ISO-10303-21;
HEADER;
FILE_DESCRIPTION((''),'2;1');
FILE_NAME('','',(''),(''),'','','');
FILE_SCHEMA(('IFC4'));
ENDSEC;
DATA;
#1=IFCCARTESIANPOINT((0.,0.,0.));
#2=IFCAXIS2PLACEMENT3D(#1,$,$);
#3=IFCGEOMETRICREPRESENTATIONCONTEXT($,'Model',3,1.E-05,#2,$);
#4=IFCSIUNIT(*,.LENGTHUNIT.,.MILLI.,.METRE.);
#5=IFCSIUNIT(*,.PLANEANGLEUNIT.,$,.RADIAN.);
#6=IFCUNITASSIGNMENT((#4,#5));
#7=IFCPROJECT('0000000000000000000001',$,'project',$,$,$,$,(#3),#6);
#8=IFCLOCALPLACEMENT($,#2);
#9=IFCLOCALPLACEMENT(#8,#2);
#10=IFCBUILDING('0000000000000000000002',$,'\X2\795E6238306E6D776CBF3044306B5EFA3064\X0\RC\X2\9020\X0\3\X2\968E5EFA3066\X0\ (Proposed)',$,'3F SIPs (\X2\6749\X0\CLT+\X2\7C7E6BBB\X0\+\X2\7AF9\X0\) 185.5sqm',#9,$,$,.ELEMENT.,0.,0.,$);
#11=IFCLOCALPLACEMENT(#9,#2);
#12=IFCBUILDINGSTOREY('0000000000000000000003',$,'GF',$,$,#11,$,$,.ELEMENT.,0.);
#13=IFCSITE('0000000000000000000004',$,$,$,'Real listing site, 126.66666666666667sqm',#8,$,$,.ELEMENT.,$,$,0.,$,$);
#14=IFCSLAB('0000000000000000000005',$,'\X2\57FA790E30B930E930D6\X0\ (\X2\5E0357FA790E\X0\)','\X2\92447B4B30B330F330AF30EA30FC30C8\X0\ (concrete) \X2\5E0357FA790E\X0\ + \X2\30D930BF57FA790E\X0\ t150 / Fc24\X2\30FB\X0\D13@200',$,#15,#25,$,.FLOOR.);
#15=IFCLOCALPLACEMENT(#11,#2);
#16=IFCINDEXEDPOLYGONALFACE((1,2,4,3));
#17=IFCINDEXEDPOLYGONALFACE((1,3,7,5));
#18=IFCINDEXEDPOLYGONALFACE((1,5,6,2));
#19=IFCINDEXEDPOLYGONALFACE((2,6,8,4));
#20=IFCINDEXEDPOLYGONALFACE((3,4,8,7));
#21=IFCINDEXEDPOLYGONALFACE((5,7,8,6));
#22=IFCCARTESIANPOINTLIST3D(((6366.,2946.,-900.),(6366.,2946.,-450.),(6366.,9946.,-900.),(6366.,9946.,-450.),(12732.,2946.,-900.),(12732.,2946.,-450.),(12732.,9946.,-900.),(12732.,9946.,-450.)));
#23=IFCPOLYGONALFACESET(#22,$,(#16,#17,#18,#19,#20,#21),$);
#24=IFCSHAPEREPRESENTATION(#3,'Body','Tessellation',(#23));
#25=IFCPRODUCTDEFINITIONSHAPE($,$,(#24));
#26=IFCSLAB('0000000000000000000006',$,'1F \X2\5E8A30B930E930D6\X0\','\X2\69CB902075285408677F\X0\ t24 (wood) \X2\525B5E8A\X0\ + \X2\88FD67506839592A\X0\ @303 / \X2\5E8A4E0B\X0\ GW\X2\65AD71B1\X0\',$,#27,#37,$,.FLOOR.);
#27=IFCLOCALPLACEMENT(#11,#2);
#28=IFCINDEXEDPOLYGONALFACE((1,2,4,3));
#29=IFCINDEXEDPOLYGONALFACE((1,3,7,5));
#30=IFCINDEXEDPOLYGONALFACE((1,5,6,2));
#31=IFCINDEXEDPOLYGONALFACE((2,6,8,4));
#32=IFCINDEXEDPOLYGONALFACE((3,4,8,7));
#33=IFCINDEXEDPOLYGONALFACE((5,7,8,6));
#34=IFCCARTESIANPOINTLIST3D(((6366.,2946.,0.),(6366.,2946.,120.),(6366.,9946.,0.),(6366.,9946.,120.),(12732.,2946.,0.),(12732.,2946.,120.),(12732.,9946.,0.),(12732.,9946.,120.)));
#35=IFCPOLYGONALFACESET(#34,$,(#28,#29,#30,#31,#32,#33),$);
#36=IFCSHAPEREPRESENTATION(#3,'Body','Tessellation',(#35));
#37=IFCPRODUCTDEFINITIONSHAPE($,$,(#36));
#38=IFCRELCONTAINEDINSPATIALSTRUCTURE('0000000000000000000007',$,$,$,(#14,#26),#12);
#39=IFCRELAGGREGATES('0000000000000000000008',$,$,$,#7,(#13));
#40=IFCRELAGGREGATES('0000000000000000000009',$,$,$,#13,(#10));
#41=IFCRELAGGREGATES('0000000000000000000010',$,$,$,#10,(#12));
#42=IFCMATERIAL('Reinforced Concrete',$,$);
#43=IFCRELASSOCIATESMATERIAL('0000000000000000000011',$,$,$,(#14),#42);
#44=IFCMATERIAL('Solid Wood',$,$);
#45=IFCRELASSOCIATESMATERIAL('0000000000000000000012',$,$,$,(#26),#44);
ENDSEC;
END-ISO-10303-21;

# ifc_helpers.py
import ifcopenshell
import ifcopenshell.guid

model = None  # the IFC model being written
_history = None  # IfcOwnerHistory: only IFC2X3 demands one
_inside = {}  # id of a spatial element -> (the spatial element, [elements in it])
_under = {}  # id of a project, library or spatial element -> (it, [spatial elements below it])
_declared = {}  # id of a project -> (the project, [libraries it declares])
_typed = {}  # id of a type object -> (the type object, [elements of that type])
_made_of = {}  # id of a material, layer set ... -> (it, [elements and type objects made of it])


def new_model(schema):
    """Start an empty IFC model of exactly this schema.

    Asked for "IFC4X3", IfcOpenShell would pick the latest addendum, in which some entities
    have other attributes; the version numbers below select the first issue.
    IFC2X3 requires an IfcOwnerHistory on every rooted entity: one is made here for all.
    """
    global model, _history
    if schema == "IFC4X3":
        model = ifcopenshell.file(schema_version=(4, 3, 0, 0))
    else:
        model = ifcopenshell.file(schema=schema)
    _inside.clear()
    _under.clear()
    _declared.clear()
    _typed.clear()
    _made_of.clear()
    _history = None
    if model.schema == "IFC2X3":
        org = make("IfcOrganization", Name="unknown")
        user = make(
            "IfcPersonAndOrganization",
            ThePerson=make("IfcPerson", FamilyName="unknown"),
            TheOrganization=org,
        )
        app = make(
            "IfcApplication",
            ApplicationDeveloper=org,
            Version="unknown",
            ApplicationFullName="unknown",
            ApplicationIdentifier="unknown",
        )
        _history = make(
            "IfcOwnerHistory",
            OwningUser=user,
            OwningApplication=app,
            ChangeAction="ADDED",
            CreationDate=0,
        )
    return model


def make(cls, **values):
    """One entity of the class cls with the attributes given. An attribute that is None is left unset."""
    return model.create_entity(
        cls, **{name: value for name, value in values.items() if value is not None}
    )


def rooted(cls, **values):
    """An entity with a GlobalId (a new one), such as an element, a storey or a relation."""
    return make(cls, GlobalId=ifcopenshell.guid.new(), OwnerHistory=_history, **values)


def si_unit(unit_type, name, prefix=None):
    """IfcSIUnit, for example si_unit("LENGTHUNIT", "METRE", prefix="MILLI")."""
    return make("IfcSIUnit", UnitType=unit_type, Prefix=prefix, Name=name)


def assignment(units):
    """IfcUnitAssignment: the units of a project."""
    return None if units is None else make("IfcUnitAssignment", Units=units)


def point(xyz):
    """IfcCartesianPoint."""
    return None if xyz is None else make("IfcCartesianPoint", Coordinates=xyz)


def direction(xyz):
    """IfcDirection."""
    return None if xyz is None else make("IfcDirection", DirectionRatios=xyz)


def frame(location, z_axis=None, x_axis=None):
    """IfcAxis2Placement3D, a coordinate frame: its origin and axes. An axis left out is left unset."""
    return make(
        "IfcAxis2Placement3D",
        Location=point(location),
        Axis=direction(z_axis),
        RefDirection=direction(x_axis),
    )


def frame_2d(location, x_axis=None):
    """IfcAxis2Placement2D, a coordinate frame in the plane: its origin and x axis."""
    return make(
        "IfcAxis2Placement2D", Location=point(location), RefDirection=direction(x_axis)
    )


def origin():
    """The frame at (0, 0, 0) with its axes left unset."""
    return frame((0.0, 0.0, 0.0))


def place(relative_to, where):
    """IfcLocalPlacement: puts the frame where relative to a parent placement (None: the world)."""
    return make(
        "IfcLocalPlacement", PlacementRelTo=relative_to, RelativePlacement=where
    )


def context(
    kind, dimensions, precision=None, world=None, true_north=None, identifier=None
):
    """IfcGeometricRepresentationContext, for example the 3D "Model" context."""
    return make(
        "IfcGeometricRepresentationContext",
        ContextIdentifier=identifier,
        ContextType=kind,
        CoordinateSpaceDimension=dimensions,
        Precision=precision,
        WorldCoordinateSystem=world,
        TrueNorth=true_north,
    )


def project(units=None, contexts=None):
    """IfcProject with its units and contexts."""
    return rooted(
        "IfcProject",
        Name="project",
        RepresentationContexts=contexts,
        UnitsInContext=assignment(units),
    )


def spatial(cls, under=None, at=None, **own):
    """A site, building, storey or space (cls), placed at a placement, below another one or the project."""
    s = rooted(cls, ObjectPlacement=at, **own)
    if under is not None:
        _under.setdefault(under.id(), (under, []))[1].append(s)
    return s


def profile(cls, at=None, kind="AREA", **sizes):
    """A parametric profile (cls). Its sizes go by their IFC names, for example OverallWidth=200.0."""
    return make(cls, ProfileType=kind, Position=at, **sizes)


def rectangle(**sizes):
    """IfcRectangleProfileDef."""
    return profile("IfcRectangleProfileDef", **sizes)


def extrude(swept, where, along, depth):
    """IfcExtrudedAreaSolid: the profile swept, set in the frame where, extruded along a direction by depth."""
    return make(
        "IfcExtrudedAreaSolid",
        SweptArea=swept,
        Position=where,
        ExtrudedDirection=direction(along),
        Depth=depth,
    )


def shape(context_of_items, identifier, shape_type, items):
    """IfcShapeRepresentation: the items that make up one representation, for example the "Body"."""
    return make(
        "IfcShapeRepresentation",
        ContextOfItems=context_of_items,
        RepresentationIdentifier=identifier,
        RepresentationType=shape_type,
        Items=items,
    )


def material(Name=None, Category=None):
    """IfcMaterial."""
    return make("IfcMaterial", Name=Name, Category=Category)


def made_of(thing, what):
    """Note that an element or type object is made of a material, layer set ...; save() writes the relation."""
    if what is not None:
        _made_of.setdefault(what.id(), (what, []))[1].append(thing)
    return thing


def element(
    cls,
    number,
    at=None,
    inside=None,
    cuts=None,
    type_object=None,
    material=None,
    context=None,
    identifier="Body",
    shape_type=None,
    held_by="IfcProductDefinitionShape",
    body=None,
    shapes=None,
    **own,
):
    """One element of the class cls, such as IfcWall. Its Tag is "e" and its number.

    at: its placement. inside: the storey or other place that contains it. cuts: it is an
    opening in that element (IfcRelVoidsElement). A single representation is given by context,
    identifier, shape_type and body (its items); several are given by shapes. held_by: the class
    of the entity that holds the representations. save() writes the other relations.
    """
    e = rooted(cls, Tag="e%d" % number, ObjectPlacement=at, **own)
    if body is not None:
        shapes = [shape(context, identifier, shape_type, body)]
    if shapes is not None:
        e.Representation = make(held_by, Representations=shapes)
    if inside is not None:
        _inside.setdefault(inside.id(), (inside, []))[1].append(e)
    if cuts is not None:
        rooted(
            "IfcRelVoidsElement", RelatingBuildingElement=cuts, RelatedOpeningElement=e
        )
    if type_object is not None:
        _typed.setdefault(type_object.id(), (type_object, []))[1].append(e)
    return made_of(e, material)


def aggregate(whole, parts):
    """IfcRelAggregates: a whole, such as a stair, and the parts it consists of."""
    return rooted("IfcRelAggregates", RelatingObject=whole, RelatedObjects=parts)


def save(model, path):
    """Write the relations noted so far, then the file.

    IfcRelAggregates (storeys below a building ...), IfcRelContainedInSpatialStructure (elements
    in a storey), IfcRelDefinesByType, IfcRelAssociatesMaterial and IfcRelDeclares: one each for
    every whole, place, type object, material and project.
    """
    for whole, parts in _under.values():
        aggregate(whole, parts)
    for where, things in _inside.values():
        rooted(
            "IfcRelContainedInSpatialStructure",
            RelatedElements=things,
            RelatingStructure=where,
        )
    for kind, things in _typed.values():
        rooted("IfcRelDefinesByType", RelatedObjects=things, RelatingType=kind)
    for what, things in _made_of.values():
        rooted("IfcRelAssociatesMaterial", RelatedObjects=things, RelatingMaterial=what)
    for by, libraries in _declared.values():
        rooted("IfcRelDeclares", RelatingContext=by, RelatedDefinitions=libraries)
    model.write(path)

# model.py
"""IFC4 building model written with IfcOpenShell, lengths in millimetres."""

from ifc_helpers import new_model, si_unit, frame, frame_2d, origin, place, context, project, spatial, rectangle, extrude, material, element, save


model = new_model("IFC4")

# Units and contexts
model_context = context("Model", 3, precision=1e-05, world=origin())
ifc_project = project(units=[si_unit("LENGTHUNIT", "METRE", prefix="MILLI"), si_unit("PLANEANGLEUNIT", "RADIAN")], contexts=[model_context])

# Site, building, storey
site_placement = place(None, origin())
site = spatial("IfcSite", under=ifc_project, at=site_placement, ObjectType="Real listing site, 126.66666666666667sqm", CompositionType="ELEMENT", RefElevation=0.0)
building_placement = place(site_placement, origin())
building = spatial("IfcBuilding", under=site, at=building_placement, Name="神戸の海沿いに建つRC造3階建て (Proposed)", ObjectType="3F SIPs (杉CLT+籾殻+竹) 185.5sqm", CompositionType="ELEMENT", ElevationOfRefHeight=0.0, ElevationOfTerrain=0.0)
storey_placement = place(building_placement, origin())
storey = spatial("IfcBuildingStorey", under=building, at=storey_placement, Name="GF", CompositionType="ELEMENT", Elevation=0.0)

# Slabs
ifc_material_1 = material(Name="Reinforced Concrete")
slab_1_placement = place(storey_placement, frame((3183.0, 1473.0, -450.0)))
element("IfcSlab", 1, at=slab_1_placement, inside=storey, material=ifc_material_1, Name="基礎スラブ (布基礎)", Description="鉄筋コンクリート (concrete) 布基礎 + ベタ基礎 t150 / Fc24・D13@200", PredefinedType="FLOOR", context=model_context, shape_type="SweptSolid", body=[
    extrude(rectangle(XDim=6366.0, YDim=7000.0, at=frame_2d((3183.0, 3500.0))), frame((3183.0, 1473.0, -450.0)), (0.0, 0.0, 1.0), 450.0),
])
ifc_material_2 = material(Name="Solid Wood")
slab_2_placement = place(storey_placement, frame((3183.0, 1473.0, 0.0)))
element("IfcSlab", 2, at=slab_2_placement, inside=storey, material=ifc_material_2, Name="1F 床スラブ", Description="構造用合板 t24 (wood) 剛床 + 製材根太 @303 / 床下 GW断熱", PredefinedType="FLOOR", context=model_context, shape_type="SweptSolid", body=[
    extrude(rectangle(XDim=6366.0, YDim=7000.0, at=frame_2d((3183.0, 3500.0))), frame((3183.0, 1473.0, 0.0)), (0.0, 0.0, 1.0), 120.0),
])

save(model, "model.ifc")
